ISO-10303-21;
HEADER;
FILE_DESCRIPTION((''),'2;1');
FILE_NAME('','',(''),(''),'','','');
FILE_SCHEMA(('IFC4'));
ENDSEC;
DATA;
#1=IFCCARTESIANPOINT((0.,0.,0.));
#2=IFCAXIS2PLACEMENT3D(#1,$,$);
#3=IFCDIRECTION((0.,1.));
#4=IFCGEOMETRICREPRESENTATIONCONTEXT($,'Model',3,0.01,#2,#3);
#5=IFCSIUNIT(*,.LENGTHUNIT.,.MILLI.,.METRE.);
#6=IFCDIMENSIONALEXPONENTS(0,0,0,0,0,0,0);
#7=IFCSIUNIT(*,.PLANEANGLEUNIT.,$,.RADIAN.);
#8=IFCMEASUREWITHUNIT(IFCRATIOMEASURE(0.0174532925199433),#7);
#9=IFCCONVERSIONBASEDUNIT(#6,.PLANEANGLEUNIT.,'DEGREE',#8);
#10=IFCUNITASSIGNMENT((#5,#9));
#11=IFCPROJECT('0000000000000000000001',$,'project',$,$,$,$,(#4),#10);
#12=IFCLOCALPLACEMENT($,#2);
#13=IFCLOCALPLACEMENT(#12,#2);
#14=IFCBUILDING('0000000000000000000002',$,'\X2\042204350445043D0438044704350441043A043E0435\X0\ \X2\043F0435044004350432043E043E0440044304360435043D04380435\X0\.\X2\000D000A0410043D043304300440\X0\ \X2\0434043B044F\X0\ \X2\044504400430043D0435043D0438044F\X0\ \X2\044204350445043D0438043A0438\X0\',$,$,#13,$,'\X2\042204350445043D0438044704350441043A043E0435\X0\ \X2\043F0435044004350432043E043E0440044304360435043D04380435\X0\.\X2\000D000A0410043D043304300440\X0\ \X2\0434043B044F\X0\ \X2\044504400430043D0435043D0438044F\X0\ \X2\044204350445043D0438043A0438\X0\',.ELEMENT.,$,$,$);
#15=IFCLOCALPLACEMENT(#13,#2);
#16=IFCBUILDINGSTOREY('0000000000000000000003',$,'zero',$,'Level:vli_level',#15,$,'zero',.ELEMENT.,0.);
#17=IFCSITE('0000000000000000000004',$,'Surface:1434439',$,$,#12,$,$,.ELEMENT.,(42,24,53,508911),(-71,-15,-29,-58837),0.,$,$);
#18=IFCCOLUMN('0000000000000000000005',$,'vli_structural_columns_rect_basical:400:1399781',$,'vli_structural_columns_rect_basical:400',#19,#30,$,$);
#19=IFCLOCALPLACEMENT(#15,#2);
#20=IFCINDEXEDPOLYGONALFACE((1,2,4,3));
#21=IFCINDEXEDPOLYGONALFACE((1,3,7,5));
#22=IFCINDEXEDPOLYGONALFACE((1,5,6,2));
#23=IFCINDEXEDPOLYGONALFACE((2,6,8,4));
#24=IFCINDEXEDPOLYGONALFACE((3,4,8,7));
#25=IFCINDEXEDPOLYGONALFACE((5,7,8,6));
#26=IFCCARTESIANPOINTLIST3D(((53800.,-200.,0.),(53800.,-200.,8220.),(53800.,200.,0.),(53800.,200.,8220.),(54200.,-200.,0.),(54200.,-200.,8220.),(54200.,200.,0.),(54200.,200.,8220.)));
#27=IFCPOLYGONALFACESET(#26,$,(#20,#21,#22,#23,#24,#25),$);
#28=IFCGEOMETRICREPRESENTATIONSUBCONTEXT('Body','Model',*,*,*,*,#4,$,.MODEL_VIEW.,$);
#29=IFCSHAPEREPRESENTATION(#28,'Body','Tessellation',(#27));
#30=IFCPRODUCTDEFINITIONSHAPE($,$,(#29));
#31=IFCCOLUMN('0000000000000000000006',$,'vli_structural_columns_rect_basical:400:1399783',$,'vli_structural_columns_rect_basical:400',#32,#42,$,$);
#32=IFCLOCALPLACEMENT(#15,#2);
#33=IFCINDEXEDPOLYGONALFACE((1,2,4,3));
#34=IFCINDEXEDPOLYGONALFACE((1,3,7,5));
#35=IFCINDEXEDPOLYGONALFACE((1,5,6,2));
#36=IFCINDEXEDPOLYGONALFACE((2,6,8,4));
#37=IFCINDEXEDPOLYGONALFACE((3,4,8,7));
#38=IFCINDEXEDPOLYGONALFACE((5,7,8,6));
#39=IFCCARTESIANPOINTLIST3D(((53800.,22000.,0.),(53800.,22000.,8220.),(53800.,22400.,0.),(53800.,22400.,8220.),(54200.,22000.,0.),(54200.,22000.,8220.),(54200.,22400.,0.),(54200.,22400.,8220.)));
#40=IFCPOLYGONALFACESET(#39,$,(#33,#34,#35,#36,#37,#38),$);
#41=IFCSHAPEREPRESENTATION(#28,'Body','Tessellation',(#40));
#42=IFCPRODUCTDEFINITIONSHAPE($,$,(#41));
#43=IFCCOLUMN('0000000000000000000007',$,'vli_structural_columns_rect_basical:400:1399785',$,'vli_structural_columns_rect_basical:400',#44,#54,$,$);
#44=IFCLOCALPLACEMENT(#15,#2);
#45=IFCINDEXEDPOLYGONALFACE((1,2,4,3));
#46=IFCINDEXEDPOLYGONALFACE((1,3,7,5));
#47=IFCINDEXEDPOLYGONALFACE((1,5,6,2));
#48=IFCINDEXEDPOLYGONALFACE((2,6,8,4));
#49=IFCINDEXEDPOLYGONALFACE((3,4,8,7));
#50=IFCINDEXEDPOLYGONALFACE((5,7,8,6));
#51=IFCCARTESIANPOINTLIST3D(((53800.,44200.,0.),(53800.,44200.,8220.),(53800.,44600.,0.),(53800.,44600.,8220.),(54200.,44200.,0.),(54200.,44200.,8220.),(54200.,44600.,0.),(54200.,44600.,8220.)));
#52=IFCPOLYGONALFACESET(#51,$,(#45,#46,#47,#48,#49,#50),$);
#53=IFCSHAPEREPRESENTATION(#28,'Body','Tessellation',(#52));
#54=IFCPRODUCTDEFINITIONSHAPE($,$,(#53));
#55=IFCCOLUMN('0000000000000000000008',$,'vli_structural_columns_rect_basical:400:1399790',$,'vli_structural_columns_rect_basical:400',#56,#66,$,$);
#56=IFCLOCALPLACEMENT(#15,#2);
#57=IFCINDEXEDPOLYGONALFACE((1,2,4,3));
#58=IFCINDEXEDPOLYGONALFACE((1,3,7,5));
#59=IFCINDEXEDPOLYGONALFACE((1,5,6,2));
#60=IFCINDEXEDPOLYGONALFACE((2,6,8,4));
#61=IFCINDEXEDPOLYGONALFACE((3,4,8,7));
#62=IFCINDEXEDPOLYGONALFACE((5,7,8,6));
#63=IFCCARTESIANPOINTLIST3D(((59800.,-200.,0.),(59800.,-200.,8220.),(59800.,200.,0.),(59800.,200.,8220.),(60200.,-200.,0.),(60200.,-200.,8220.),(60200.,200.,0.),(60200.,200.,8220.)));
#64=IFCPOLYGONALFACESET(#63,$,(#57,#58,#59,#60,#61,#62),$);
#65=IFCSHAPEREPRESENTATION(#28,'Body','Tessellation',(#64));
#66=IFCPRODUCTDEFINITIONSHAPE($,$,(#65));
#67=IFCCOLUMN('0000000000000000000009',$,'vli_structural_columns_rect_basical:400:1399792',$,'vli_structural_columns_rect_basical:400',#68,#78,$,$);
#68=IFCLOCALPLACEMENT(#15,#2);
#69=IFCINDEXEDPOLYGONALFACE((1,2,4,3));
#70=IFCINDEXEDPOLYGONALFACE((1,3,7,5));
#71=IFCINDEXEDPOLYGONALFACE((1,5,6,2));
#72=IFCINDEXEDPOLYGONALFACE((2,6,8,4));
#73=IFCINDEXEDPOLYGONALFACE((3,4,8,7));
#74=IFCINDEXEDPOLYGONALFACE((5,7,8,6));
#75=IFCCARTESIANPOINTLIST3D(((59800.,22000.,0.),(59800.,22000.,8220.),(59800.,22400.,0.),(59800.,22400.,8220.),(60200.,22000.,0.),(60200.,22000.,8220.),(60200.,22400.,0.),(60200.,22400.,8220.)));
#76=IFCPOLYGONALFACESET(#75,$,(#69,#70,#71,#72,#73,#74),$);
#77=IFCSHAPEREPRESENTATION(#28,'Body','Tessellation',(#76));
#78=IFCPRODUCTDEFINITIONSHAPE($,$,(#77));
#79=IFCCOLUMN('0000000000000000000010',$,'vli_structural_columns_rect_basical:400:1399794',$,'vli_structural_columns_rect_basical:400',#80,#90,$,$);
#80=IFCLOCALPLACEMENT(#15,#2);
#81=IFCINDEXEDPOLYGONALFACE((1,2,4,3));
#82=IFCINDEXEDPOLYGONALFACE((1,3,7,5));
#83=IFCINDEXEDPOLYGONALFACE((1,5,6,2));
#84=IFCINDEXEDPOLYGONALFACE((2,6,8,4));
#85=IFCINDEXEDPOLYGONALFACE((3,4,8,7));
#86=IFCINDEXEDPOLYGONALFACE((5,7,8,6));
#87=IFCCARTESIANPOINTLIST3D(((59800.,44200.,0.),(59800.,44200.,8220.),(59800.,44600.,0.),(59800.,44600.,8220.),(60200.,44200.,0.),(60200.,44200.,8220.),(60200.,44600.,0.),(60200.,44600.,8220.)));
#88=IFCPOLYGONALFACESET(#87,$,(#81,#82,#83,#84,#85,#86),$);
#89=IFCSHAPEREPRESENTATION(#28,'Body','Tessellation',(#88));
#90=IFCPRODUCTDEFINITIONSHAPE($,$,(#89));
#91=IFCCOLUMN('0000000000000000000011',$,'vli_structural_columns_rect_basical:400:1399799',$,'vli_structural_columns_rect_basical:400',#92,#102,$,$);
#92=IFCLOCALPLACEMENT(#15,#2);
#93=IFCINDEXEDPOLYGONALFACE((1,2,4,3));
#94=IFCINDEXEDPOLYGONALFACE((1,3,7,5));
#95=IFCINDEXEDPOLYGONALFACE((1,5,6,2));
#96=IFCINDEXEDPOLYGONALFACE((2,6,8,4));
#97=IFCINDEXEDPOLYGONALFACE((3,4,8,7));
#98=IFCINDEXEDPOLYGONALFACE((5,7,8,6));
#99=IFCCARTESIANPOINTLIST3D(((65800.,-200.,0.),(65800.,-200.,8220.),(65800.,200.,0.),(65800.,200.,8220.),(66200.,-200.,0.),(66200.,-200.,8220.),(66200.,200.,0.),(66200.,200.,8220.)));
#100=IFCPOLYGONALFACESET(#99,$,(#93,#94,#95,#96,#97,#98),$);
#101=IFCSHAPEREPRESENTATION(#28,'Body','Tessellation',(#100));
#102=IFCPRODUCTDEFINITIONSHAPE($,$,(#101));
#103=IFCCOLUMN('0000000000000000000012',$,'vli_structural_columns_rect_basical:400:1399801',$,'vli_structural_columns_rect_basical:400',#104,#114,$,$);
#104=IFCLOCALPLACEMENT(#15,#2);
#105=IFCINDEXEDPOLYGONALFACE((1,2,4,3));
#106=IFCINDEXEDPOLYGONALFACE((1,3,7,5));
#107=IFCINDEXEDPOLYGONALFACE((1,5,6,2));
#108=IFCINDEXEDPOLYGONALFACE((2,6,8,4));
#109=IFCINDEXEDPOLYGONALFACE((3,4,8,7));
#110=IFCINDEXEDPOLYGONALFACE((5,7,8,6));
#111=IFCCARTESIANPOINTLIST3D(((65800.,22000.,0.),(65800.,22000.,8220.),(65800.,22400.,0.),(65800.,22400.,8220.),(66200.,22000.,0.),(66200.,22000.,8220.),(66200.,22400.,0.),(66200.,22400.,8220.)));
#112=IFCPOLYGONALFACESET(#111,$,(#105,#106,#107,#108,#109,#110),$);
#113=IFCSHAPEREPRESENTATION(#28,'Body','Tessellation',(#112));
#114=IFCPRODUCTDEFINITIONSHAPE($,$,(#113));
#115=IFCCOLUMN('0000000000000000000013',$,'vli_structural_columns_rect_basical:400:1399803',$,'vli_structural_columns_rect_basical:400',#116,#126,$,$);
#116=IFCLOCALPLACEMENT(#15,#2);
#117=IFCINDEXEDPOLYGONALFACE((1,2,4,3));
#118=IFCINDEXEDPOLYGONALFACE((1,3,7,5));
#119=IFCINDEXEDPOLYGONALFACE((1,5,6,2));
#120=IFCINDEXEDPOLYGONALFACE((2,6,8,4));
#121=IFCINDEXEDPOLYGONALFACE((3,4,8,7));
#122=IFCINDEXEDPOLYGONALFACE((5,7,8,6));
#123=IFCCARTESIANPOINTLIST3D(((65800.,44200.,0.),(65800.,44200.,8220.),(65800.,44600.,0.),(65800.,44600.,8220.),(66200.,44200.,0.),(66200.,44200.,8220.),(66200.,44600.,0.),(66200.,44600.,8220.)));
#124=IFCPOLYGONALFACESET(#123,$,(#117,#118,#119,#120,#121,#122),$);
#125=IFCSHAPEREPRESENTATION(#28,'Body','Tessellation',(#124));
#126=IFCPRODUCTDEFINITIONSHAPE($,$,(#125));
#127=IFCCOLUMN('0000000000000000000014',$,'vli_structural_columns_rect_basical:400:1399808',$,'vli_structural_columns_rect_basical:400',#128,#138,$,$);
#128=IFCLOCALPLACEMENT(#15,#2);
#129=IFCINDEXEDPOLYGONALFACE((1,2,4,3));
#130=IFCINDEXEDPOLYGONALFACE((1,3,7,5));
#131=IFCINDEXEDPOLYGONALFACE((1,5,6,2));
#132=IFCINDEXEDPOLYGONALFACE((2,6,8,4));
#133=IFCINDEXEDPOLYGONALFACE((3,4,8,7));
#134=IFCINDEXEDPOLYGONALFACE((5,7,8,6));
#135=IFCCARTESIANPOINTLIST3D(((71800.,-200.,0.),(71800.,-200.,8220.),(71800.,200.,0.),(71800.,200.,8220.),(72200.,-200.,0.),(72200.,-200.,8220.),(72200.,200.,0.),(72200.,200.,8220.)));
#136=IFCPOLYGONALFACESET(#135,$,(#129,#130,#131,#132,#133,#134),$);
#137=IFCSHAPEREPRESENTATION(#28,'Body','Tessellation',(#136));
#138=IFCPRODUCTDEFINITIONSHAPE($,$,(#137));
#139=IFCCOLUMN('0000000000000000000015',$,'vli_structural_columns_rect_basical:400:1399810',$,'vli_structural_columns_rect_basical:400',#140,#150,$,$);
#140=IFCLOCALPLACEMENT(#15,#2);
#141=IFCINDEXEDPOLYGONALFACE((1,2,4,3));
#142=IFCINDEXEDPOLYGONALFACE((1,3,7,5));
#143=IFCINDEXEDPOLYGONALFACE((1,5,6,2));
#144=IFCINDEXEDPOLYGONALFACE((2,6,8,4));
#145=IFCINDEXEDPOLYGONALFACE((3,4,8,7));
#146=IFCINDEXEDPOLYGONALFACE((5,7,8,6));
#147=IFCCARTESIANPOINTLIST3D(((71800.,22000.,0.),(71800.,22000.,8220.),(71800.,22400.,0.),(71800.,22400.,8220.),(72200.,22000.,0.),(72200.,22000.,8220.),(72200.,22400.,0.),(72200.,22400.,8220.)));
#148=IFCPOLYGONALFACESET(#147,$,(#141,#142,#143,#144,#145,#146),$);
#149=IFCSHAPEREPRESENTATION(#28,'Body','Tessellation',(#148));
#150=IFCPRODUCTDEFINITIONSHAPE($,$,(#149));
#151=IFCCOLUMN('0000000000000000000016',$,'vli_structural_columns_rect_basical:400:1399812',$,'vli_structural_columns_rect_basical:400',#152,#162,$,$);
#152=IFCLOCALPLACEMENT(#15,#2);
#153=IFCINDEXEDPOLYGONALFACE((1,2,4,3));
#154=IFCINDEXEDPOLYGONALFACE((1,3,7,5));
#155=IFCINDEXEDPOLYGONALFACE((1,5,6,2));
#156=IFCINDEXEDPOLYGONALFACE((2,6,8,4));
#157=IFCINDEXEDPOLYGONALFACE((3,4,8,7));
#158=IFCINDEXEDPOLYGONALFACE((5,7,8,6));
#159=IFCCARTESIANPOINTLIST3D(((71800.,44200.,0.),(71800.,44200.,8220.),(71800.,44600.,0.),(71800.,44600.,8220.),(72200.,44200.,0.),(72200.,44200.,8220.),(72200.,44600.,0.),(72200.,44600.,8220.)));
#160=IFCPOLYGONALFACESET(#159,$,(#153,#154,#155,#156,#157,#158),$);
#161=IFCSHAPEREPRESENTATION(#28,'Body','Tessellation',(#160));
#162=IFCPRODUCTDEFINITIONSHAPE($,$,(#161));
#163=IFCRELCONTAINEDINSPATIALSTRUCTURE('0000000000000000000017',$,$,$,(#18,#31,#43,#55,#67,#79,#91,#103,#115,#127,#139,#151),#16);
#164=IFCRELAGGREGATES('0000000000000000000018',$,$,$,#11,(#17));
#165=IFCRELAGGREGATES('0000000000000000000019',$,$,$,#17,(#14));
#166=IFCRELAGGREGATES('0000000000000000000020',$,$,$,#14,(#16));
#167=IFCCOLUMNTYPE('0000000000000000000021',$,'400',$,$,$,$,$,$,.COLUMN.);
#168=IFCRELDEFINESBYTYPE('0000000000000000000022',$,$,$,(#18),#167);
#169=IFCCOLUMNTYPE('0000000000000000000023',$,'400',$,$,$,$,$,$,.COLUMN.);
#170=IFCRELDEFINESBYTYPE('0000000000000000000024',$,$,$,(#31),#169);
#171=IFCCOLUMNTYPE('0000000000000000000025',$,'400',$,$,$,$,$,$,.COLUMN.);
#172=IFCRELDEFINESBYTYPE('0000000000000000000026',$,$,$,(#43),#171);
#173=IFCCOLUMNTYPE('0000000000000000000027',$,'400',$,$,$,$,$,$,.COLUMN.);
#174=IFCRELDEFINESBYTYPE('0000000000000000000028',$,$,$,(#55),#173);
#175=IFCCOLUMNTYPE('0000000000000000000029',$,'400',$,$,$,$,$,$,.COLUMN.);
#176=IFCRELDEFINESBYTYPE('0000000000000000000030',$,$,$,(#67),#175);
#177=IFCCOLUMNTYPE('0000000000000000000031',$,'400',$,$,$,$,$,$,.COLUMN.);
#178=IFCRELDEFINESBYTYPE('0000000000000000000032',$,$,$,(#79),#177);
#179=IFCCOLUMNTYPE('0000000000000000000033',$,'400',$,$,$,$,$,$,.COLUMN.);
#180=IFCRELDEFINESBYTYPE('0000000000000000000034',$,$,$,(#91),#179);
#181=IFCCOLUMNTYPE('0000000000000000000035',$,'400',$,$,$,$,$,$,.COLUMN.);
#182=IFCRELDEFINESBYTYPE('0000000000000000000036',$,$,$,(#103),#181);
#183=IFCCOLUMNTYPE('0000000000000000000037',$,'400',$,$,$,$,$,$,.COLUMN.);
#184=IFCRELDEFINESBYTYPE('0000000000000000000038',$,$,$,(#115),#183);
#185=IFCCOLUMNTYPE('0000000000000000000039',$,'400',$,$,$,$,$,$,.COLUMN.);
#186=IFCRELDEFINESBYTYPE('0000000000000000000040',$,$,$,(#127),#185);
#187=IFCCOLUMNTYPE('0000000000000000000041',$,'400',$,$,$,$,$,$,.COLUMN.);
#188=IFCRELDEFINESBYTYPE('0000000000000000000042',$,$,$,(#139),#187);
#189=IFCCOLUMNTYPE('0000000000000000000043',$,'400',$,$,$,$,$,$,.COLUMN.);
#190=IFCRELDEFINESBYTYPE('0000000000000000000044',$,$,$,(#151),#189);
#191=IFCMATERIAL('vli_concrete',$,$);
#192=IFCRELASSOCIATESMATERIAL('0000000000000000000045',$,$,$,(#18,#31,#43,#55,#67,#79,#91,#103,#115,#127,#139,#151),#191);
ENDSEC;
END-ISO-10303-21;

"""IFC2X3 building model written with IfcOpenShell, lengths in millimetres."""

from ifc_helpers import new_model, entity, si_unit, converted_unit, direction, frame, frame_2d, origin, origin_2d_with_axis, place, context, subcontext, project, spatial, rectangle, extrude, source, transform, mapped, material, type_object, type_shapes, element, save


model = new_model("IFC2X3")

# Units and contexts
model_context = context("Model", 3, precision=0.01, world=origin(), true_north=direction((0.0, 1.0)))
body_context = subcontext(model_context, "Body", "Model", "MODEL_VIEW")
ifc_project = project(units=[si_unit("LENGTHUNIT", "METRE", prefix="MILLI"), converted_unit("PLANEANGLEUNIT", "DEGREE", entity("IfcRatioMeasure", 0.0174532925199433), si_unit("PLANEANGLEUNIT", "RADIAN"), dimensions=[0, 0, 0, 0, 0, 0, 0])], contexts=[model_context])

# Site, building, storey
site_placement = place(None, origin())
site = spatial("IfcSite", under=ifc_project, at=site_placement, Name="Surface:1434439", CompositionType="ELEMENT", RefLatitude=(42, 24, 53, 508911), RefLongitude=(-71, -15, -29, -58837), RefElevation=0.0)
building_placement = place(site_placement, origin())
building = spatial("IfcBuilding", under=site, at=building_placement, Name="Техническое перевооружение.\r\nАнгар для хранения техники", LongName="Техническое перевооружение.\r\nАнгар для хранения техники", CompositionType="ELEMENT")
storey_placement = place(building_placement, origin())
storey = spatial("IfcBuildingStorey", under=building, at=storey_placement, Name="zero", ObjectType="Level:vli_level", LongName="zero", CompositionType="ELEMENT", Elevation=0.0)

# Columns
ifc_material_1 = material(Name="vli_concrete")
column_type_1 = type_object("IfcColumnType", Name="400", PredefinedType="COLUMN")
shared_shape_1 = source(origin(), body_context, "Body", "SweptSolid", [
    extrude(rectangle(XDim=400.0, YDim=400.0, at=origin_2d_with_axis()), frame((54000.0, 0.0, 0.0), z_axis=(0.0, 0.0, 1.0), x_axis=(0.0, -1.0, 0.0)), (0.0, 0.0, 1.0), 8220.0),
])
type_shapes(column_type_1, [shared_shape_1])
column_1_placement = place(storey_placement, origin())
element("IfcColumn", 1, at=column_1_placement, inside=storey, type_object=column_type_1, material=ifc_material_1, Name="vli_structural_columns_rect_basical:400:1399781", ObjectType="vli_structural_columns_rect_basical:400", context=body_context, shape_type="MappedRepresentation", body=[
    mapped(shared_shape_1, transform((0.0, 0.0, 0.0), scale=1.0)),
])
column_type_2 = type_object("IfcColumnType", Name="400", PredefinedType="COLUMN")
shared_shape_2 = source(origin(), body_context, "Body", "SweptSolid", [
    extrude(rectangle(XDim=400.0, YDim=400.0, at=frame_2d((0.0, 0.0), x_axis=(1.0, 0.0))), frame((54000.0, 22200.0, 0.0), z_axis=(0.0, 0.0, 1.0), x_axis=(0.0, -1.0, 0.0)), (0.0, 0.0, 1.0), 8220.0),
])
type_shapes(column_type_2, [shared_shape_2])
column_2_placement = place(storey_placement, origin())
element("IfcColumn", 2, at=column_2_placement, inside=storey, type_object=column_type_2, material=ifc_material_1, Name="vli_structural_columns_rect_basical:400:1399783", ObjectType="vli_structural_columns_rect_basical:400", context=body_context, shape_type="MappedRepresentation", body=[
    mapped(shared_shape_2, transform((0.0, 0.0, 0.0), scale=1.0)),
])
column_type_3 = type_object("IfcColumnType", Name="400", PredefinedType="COLUMN")
shared_shape_3 = source(origin(), body_context, "Body", "SweptSolid", [
    extrude(rectangle(XDim=400.0, YDim=400.0, at=origin_2d_with_axis()), frame((54000.0, 44400.0, 0.0), z_axis=(0.0, 0.0, 1.0), x_axis=(0.0, -1.0, 0.0)), (0.0, 0.0, 1.0), 8220.0),
])
type_shapes(column_type_3, [shared_shape_3])
column_3_placement = place(storey_placement, origin())
element("IfcColumn", 3, at=column_3_placement, inside=storey, type_object=column_type_3, material=ifc_material_1, Name="vli_structural_columns_rect_basical:400:1399785", ObjectType="vli_structural_columns_rect_basical:400", context=body_context, shape_type="MappedRepresentation", body=[
    mapped(shared_shape_3, transform((0.0, 0.0, 0.0), scale=1.0)),
])
column_type_4 = type_object("IfcColumnType", Name="400", PredefinedType="COLUMN")
shared_shape_4 = source(origin(), body_context, "Body", "SweptSolid", [
    extrude(rectangle(XDim=400.0, YDim=400.0, at=origin_2d_with_axis()), frame((60000.0, 0.0, 0.0), z_axis=(0.0, 0.0, 1.0), x_axis=(0.0, -1.0, 0.0)), (0.0, 0.0, 1.0), 8220.0),
])
type_shapes(column_type_4, [shared_shape_4])
column_4_placement = place(storey_placement, origin())
element("IfcColumn", 4, at=column_4_placement, inside=storey, type_object=column_type_4, material=ifc_material_1, Name="vli_structural_columns_rect_basical:400:1399790", ObjectType="vli_structural_columns_rect_basical:400", context=body_context, shape_type="MappedRepresentation", body=[
    mapped(shared_shape_4, transform((0.0, 0.0, 0.0), scale=1.0)),
])
column_type_5 = type_object("IfcColumnType", Name="400", PredefinedType="COLUMN")
shared_shape_5 = source(origin(), body_context, "Body", "SweptSolid", [
    extrude(rectangle(XDim=400.0, YDim=400.0, at=frame_2d((0.0, 0.0), x_axis=(1.0, 0.0))), frame((60000.0, 22200.0, 0.0), z_axis=(0.0, 0.0, 1.0), x_axis=(0.0, -1.0, 0.0)), (0.0, 0.0, 1.0), 8220.0),
])
type_shapes(column_type_5, [shared_shape_5])
column_5_placement = place(storey_placement, origin())
element("IfcColumn", 5, at=column_5_placement, inside=storey, type_object=column_type_5, material=ifc_material_1, Name="vli_structural_columns_rect_basical:400:1399792", ObjectType="vli_structural_columns_rect_basical:400", context=body_context, shape_type="MappedRepresentation", body=[
    mapped(shared_shape_5, transform((0.0, 0.0, 0.0), scale=1.0)),
])
column_type_6 = type_object("IfcColumnType", Name="400", PredefinedType="COLUMN")
shared_shape_6 = source(origin(), body_context, "Body", "SweptSolid", [
    extrude(rectangle(XDim=400.0, YDim=400.0, at=origin_2d_with_axis()), frame((60000.0, 44400.0, 0.0), z_axis=(0.0, 0.0, 1.0), x_axis=(0.0, -1.0, 0.0)), (0.0, 0.0, 1.0), 8220.0),
])
type_shapes(column_type_6, [shared_shape_6])
column_6_placement = place(storey_placement, origin())
element("IfcColumn", 6, at=column_6_placement, inside=storey, type_object=column_type_6, material=ifc_material_1, Name="vli_structural_columns_rect_basical:400:1399794", ObjectType="vli_structural_columns_rect_basical:400", context=body_context, shape_type="MappedRepresentation", body=[
    mapped(shared_shape_6, transform((0.0, 0.0, 0.0), scale=1.0)),
])
column_type_7 = type_object("IfcColumnType", Name="400", PredefinedType="COLUMN")
shared_shape_7 = source(origin(), body_context, "Body", "SweptSolid", [
    extrude(rectangle(XDim=400.0, YDim=400.0, at=origin_2d_with_axis()), frame((66000.0, 0.0, 0.0), z_axis=(0.0, 0.0, 1.0), x_axis=(0.0, -1.0, 0.0)), (0.0, 0.0, 1.0), 8220.0),
])
type_shapes(column_type_7, [shared_shape_7])
column_7_placement = place(storey_placement, origin())
element("IfcColumn", 7, at=column_7_placement, inside=storey, type_object=column_type_7, material=ifc_material_1, Name="vli_structural_columns_rect_basical:400:1399799", ObjectType="vli_structural_columns_rect_basical:400", context=body_context, shape_type="MappedRepresentation", body=[
    mapped(shared_shape_7, transform((0.0, 0.0, 0.0), scale=1.0)),
])
column_type_8 = type_object("IfcColumnType", Name="400", PredefinedType="COLUMN")
shared_shape_8 = source(origin(), body_context, "Body", "SweptSolid", [
    extrude(rectangle(XDim=400.0, YDim=400.0, at=frame_2d((0.0, 0.0), x_axis=(1.0, 0.0))), frame((66000.0, 22200.0, 0.0), z_axis=(0.0, 0.0, 1.0), x_axis=(0.0, -1.0, 0.0)), (0.0, 0.0, 1.0), 8220.0),
])
type_shapes(column_type_8, [shared_shape_8])
column_8_placement = place(storey_placement, origin())
element("IfcColumn", 8, at=column_8_placement, inside=storey, type_object=column_type_8, material=ifc_material_1, Name="vli_structural_columns_rect_basical:400:1399801", ObjectType="vli_structural_columns_rect_basical:400", context=body_context, shape_type="MappedRepresentation", body=[
    mapped(shared_shape_8, transform((0.0, 0.0, 0.0), scale=1.0)),
])
column_type_9 = type_object("IfcColumnType", Name="400", PredefinedType="COLUMN")
shared_shape_9 = source(origin(), body_context, "Body", "SweptSolid", [
    extrude(rectangle(XDim=400.0, YDim=400.0, at=origin_2d_with_axis()), frame((66000.0, 44400.0, 0.0), z_axis=(0.0, 0.0, 1.0), x_axis=(0.0, -1.0, 0.0)), (0.0, 0.0, 1.0), 8220.0),
])
type_shapes(column_type_9, [shared_shape_9])
column_9_placement = place(storey_placement, origin())
element("IfcColumn", 9, at=column_9_placement, inside=storey, type_object=column_type_9, material=ifc_material_1, Name="vli_structural_columns_rect_basical:400:1399803", ObjectType="vli_structural_columns_rect_basical:400", context=body_context, shape_type="MappedRepresentation", body=[
    mapped(shared_shape_9, transform((0.0, 0.0, 0.0), scale=1.0)),
])
column_type_10 = type_object("IfcColumnType", Name="400", PredefinedType="COLUMN")
shared_shape_10 = source(origin(), body_context, "Body", "SweptSolid", [
    extrude(rectangle(XDim=400.0, YDim=400.0, at=origin_2d_with_axis()), frame((72000.0, 0.0, 0.0), z_axis=(0.0, 0.0, 1.0), x_axis=(0.0, -1.0, 0.0)), (0.0, 0.0, 1.0), 8220.0),
])
type_shapes(column_type_10, [shared_shape_10])
column_10_placement = place(storey_placement, origin())
element("IfcColumn", 10, at=column_10_placement, inside=storey, type_object=column_type_10, material=ifc_material_1, Name="vli_structural_columns_rect_basical:400:1399808", ObjectType="vli_structural_columns_rect_basical:400", context=body_context, shape_type="MappedRepresentation", body=[
    mapped(shared_shape_10, transform((0.0, 0.0, 0.0), scale=1.0)),
])
column_type_11 = type_object("IfcColumnType", Name="400", PredefinedType="COLUMN")
shared_shape_11 = source(origin(), body_context, "Body", "SweptSolid", [
    extrude(rectangle(XDim=400.0, YDim=400.0, at=frame_2d((0.0, 0.0), x_axis=(1.0, 0.0))), frame((72000.0, 22200.0, 0.0), z_axis=(0.0, 0.0, 1.0), x_axis=(0.0, -1.0, 0.0)), (0.0, 0.0, 1.0), 8220.0),
])
type_shapes(column_type_11, [shared_shape_11])
column_11_placement = place(storey_placement, origin())
element("IfcColumn", 11, at=column_11_placement, inside=storey, type_object=column_type_11, material=ifc_material_1, Name="vli_structural_columns_rect_basical:400:1399810", ObjectType="vli_structural_columns_rect_basical:400", context=body_context, shape_type="MappedRepresentation", body=[
    mapped(shared_shape_11, transform((0.0, 0.0, 0.0), scale=1.0)),
])
column_type_12 = type_object("IfcColumnType", Name="400", PredefinedType="COLUMN")
shared_shape_12 = source(origin(), body_context, "Body", "SweptSolid", [
    extrude(rectangle(XDim=400.0, YDim=400.0, at=origin_2d_with_axis()), frame((72000.0, 44400.0, 0.0), z_axis=(0.0, 0.0, 1.0), x_axis=(0.0, -1.0, 0.0)), (0.0, 0.0, 1.0), 8220.0),
])
type_shapes(column_type_12, [shared_shape_12])
column_12_placement = place(storey_placement, origin())
element("IfcColumn", 12, at=column_12_placement, inside=storey, type_object=column_type_12, material=ifc_material_1, Name="vli_structural_columns_rect_basical:400:1399812", ObjectType="vli_structural_columns_rect_basical:400", context=body_context, shape_type="MappedRepresentation", body=[
    mapped(shared_shape_12, transform((0.0, 0.0, 0.0), scale=1.0)),
])

save(model, "model.ifc")
